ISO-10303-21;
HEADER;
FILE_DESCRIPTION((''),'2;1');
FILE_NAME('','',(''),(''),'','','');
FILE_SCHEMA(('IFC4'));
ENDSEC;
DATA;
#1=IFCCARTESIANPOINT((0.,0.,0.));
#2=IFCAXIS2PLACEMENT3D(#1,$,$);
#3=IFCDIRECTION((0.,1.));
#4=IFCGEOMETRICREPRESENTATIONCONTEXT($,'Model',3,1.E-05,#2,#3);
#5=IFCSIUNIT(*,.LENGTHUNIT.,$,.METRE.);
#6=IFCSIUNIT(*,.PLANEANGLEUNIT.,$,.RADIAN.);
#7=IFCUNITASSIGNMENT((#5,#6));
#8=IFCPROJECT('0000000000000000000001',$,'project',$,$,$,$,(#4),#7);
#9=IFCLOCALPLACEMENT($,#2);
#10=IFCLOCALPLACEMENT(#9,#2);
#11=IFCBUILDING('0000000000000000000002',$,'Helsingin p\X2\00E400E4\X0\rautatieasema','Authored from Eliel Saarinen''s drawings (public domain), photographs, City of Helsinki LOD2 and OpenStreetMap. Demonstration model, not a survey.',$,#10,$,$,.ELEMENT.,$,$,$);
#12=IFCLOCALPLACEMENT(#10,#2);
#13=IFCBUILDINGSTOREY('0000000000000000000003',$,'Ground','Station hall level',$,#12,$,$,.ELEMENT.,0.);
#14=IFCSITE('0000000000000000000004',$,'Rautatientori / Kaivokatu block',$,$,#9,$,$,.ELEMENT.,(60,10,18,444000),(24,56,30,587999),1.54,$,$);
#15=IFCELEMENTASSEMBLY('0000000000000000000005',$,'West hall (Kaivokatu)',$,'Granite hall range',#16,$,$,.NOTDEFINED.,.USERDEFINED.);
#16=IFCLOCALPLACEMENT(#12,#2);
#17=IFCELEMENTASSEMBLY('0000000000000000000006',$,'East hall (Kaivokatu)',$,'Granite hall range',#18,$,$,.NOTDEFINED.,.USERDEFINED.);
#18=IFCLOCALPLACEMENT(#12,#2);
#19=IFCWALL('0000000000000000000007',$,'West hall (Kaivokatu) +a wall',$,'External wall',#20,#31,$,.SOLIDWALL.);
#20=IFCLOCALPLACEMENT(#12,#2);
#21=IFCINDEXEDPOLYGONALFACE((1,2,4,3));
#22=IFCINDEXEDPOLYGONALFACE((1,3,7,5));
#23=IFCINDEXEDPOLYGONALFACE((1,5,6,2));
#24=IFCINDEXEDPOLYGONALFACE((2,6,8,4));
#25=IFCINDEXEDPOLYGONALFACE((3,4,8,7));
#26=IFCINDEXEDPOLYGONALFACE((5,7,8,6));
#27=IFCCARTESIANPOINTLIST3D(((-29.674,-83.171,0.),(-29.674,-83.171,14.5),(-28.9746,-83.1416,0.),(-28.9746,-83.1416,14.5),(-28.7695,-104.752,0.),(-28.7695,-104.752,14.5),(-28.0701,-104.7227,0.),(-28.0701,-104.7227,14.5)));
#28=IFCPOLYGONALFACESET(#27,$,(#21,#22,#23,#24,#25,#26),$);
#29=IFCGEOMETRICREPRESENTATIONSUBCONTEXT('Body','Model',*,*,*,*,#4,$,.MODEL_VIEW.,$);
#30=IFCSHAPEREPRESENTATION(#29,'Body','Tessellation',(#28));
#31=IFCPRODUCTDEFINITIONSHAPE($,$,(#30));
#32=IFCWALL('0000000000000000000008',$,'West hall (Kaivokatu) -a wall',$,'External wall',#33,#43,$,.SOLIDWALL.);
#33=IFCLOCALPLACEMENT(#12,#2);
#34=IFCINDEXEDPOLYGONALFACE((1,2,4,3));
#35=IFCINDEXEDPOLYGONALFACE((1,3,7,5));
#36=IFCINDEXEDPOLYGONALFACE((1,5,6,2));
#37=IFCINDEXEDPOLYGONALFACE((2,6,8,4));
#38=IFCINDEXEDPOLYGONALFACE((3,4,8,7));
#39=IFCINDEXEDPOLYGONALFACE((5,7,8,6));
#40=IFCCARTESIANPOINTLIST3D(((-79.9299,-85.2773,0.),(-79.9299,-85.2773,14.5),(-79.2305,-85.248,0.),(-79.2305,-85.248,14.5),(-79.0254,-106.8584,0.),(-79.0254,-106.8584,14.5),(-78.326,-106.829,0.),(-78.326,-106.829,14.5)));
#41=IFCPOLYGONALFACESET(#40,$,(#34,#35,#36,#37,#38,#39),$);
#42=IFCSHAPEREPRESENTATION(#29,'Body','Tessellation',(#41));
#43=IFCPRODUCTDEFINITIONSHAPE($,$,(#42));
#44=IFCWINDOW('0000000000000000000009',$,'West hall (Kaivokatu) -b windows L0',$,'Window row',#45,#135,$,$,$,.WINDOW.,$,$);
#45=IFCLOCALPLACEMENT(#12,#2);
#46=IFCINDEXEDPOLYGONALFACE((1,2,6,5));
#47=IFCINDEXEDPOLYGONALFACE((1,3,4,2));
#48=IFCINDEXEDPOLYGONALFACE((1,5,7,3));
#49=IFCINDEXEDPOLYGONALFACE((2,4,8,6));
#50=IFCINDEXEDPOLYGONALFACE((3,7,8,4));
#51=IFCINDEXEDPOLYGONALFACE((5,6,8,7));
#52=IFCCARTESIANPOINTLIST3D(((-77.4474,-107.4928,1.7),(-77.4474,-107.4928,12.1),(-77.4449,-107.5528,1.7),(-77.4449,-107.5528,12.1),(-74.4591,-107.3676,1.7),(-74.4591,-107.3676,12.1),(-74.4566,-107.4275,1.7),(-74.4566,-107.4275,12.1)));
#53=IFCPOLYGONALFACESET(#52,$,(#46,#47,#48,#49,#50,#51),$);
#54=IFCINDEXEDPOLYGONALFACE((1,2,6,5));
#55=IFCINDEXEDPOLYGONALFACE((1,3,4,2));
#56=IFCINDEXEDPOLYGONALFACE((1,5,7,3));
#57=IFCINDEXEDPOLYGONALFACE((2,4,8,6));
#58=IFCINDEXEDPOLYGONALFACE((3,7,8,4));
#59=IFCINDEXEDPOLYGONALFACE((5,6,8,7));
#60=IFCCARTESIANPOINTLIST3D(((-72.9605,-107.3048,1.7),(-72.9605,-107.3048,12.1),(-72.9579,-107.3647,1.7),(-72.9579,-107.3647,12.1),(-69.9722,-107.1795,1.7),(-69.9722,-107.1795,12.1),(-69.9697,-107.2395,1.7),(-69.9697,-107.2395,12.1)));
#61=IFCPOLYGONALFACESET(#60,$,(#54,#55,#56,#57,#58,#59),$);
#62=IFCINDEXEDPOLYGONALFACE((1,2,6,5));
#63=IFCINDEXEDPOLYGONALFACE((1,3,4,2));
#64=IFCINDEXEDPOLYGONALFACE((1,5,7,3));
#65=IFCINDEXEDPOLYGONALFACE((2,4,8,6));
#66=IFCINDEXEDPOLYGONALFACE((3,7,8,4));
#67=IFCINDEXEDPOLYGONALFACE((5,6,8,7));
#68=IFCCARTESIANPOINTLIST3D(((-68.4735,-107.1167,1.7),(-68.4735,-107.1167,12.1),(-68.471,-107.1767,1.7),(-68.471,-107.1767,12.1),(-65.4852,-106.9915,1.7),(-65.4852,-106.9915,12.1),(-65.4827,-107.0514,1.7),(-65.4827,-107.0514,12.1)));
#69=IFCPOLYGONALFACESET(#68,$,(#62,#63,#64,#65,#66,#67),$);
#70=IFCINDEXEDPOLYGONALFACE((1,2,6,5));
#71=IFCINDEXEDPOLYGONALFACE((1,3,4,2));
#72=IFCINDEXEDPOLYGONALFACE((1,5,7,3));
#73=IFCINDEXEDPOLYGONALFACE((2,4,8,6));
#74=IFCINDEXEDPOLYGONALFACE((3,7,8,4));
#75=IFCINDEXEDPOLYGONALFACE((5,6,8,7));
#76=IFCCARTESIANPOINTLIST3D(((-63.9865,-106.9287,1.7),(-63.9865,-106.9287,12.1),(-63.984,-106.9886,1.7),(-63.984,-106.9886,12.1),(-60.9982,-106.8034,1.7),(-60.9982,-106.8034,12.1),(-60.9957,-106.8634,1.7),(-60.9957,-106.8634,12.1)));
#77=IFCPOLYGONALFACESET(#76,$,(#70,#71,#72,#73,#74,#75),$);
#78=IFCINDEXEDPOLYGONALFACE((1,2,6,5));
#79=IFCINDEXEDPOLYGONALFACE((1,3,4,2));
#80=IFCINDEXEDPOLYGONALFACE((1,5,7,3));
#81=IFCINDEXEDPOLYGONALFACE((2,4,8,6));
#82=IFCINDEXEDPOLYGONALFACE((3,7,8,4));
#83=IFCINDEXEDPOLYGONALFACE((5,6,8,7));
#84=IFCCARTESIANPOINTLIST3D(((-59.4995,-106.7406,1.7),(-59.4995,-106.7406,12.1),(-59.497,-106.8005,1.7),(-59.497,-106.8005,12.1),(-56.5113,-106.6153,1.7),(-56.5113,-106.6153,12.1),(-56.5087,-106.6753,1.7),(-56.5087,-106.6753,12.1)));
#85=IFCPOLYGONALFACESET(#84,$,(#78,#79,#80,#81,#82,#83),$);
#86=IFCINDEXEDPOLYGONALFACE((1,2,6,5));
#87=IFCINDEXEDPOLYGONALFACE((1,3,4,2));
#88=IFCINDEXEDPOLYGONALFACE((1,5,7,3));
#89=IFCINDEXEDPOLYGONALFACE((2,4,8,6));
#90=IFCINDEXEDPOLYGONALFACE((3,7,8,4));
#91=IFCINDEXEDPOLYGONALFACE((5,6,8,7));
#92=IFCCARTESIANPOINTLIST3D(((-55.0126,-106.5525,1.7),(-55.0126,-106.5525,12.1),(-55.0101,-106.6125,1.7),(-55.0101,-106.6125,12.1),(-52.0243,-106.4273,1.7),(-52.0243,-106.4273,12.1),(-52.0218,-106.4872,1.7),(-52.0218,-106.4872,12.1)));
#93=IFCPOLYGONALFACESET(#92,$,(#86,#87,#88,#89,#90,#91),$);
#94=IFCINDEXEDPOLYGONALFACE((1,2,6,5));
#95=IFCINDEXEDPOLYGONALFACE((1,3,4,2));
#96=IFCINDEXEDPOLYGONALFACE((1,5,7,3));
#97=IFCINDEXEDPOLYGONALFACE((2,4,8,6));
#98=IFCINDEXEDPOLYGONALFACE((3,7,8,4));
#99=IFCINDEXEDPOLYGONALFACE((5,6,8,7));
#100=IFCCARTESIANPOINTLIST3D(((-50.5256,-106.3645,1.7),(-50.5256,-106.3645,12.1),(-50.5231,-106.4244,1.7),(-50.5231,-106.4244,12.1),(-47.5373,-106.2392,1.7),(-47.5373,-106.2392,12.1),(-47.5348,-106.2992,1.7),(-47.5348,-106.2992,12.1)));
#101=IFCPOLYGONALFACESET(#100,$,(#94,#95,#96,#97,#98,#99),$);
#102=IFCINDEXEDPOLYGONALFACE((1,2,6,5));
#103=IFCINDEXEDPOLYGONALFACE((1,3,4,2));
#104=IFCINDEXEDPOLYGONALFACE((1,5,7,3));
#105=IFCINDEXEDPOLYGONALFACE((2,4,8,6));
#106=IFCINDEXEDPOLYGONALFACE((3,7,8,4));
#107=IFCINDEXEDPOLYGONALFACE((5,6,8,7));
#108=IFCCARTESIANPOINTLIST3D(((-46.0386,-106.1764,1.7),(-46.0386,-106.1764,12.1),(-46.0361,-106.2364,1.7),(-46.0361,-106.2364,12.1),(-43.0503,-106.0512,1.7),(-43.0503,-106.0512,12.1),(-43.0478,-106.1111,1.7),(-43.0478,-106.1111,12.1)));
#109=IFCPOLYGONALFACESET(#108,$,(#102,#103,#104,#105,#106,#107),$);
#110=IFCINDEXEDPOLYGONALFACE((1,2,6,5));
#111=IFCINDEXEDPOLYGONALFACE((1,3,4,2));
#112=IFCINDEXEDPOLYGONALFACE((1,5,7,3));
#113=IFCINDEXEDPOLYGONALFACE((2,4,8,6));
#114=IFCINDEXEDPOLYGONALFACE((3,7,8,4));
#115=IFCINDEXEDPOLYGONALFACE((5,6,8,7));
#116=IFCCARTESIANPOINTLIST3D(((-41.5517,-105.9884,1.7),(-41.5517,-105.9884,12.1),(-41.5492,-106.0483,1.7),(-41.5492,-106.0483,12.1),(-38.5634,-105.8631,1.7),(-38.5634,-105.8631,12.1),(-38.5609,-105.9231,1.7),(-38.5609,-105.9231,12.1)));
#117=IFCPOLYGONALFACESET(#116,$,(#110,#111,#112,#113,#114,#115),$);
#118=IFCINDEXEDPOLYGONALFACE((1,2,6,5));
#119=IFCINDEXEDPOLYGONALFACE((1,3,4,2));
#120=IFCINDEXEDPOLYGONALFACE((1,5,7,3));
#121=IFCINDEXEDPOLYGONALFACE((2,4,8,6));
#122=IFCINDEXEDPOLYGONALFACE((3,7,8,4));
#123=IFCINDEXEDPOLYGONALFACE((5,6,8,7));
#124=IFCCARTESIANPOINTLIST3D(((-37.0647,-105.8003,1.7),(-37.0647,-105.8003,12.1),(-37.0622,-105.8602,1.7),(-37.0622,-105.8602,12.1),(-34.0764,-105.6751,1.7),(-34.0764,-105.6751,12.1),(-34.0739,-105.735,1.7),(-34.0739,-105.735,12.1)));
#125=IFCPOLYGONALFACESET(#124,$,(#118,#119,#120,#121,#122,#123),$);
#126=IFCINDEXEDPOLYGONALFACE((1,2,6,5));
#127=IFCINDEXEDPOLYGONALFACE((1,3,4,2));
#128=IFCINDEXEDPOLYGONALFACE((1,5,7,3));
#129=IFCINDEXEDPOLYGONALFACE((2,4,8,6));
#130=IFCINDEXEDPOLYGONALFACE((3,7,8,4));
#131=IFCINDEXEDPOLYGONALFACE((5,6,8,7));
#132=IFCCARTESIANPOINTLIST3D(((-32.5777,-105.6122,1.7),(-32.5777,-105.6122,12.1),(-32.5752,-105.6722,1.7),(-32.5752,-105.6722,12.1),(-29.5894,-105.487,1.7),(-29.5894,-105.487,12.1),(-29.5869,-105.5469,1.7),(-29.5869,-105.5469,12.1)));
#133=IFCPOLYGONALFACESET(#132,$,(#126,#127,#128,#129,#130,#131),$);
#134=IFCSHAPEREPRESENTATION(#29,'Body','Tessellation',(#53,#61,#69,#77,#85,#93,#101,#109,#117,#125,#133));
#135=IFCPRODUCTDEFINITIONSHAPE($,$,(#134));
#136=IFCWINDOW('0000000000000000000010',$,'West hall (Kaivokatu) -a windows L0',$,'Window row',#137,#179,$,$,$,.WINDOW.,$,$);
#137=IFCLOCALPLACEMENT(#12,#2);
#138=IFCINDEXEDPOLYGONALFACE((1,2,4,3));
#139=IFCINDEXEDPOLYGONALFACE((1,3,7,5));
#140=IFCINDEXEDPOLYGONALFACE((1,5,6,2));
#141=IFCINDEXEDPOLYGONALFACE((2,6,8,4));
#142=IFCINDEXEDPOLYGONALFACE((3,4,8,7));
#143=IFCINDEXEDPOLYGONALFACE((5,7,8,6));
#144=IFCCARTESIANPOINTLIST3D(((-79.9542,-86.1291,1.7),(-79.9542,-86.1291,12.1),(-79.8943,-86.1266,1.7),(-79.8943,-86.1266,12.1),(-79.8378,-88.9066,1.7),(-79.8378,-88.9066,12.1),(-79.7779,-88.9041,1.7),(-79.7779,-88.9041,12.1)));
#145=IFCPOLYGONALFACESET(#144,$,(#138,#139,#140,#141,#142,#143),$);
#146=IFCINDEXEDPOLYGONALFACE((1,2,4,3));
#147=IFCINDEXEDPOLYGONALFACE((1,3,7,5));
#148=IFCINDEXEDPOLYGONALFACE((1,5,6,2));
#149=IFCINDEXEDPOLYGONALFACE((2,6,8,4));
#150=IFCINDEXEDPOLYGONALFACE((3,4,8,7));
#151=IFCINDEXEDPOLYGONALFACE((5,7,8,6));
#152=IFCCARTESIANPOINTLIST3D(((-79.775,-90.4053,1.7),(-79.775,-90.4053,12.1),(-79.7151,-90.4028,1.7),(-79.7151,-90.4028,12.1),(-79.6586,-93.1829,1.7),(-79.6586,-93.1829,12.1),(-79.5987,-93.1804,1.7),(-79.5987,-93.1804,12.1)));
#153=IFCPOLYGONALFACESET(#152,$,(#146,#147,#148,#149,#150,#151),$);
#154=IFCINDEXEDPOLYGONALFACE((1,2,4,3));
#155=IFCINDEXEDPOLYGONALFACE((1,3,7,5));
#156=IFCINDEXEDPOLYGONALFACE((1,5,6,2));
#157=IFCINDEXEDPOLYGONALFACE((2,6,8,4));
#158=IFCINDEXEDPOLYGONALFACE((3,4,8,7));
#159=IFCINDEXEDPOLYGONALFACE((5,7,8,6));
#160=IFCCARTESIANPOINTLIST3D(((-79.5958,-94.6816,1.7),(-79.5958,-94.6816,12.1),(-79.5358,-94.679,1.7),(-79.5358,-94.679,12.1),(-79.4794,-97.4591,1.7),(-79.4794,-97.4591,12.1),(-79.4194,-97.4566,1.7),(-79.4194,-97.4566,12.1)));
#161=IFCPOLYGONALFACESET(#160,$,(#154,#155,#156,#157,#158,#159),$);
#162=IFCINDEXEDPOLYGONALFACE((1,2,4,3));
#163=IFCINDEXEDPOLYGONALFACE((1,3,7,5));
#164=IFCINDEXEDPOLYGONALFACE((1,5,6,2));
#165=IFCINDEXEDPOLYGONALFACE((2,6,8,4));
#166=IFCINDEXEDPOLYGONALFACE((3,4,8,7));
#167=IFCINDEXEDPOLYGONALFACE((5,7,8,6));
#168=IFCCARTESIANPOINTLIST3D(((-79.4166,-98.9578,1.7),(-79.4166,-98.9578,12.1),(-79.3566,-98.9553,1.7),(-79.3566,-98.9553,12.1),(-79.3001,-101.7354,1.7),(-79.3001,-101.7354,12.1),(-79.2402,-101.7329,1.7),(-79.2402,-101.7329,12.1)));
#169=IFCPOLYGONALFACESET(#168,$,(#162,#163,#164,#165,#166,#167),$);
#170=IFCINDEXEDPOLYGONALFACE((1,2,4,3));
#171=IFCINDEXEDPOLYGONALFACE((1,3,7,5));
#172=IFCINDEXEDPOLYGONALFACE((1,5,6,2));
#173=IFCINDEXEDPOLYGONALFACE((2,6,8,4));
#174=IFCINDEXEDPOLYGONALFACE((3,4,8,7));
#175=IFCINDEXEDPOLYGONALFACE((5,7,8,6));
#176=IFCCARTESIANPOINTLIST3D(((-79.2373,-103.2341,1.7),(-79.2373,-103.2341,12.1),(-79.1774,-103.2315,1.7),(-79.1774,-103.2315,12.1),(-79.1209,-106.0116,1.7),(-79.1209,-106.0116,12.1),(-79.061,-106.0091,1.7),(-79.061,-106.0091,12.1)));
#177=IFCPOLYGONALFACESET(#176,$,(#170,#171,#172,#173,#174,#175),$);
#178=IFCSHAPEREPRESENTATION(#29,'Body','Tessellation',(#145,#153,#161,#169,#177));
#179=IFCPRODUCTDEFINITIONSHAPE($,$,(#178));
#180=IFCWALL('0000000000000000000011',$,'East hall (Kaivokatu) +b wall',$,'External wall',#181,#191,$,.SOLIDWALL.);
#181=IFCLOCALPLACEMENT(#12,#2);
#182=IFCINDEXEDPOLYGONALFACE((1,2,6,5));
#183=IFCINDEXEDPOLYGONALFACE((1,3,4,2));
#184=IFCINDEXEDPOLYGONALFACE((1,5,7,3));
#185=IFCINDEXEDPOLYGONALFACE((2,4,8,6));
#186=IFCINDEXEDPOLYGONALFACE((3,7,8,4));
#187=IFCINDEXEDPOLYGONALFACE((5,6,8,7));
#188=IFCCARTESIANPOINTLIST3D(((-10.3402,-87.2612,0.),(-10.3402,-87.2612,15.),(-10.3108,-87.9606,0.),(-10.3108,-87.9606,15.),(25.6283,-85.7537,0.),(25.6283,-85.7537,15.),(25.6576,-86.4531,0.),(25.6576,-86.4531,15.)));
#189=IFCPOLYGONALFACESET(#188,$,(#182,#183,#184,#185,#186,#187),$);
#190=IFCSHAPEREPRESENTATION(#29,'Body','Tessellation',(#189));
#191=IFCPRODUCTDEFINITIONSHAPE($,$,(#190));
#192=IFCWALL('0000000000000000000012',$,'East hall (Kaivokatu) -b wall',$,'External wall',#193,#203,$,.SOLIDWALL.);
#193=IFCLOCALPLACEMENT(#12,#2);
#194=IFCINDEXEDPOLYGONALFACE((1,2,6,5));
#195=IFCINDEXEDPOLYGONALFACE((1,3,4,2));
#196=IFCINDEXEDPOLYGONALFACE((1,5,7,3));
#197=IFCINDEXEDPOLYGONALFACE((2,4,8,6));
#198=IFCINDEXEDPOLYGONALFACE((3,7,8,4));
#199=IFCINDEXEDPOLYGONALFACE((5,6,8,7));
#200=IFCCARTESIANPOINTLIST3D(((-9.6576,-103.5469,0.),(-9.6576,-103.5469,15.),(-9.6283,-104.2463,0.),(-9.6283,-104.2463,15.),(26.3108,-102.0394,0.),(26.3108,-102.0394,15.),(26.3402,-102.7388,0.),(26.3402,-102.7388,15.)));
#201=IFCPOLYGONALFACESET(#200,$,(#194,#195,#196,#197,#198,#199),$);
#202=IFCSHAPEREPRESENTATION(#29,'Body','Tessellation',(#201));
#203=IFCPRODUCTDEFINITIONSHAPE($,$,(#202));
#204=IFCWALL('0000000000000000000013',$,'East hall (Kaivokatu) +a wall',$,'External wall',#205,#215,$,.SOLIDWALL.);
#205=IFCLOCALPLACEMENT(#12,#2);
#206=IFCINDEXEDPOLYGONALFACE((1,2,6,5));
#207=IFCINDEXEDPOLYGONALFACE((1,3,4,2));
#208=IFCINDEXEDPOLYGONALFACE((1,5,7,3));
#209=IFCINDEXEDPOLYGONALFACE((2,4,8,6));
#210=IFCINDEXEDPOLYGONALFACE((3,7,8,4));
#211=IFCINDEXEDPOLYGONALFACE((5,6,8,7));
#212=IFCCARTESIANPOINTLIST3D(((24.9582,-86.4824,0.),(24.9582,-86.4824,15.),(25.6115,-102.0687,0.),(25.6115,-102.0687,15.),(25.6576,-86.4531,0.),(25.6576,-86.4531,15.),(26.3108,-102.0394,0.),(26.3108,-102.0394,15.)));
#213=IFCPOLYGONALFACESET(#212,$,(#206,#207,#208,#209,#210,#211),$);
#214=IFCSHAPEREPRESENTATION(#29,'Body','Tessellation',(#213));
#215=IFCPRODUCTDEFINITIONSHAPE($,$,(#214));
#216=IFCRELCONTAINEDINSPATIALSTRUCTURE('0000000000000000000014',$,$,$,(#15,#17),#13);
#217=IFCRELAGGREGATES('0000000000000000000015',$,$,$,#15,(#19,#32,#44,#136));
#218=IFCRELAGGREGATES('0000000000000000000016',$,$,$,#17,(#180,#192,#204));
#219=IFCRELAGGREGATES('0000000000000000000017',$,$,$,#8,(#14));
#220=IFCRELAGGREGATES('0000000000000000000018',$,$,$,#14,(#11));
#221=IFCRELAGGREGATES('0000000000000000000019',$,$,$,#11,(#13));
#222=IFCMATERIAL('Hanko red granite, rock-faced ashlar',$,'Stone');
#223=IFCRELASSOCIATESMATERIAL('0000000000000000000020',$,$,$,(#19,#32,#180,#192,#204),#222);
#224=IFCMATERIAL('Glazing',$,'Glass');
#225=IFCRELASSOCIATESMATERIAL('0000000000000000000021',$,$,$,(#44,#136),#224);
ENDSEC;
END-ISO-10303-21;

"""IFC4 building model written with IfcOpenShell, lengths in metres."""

from ifc_helpers import new_model, si_unit, direction, frame, frame_2d, origin, place, context, subcontext, project, spatial, rectangle, extrude, material, element, aggregate, save


model = new_model("IFC4")

# Units and contexts
model_context = context("Model", 3, precision=1e-05, world=origin(), true_north=direction((0.0, 1.0)))
body_context = subcontext(model_context, "Body", "Model", "MODEL_VIEW")
ifc_project = project(units=[si_unit("LENGTHUNIT", "METRE"), si_unit("PLANEANGLEUNIT", "RADIAN")], contexts=[model_context])

# Site, building, storey
site_placement = place(None, origin())
site = spatial("IfcSite", under=ifc_project, at=site_placement, Name="Rautatientori / Kaivokatu block", CompositionType="ELEMENT", RefLatitude=(60, 10, 18, 444000), RefLongitude=(24, 56, 30, 587999), RefElevation=1.54)
building_placement = place(site_placement, origin())
building = spatial("IfcBuilding", under=site, at=building_placement, Name="Helsingin päärautatieasema", Description="Authored from Eliel Saarinen's drawings (public domain), photographs, City of Helsinki LOD2 and OpenStreetMap. Demonstration model, not a survey.", CompositionType="ELEMENT")
storey_placement = place(building_placement, origin())
storey = spatial("IfcBuildingStorey", under=building, at=storey_placement, Name="Ground", Description="Station hall level", CompositionType="ELEMENT", Elevation=0.0)

# Element assemblies
assembly_1_placement = place(building_placement, origin())
assembly_1 = element("IfcElementAssembly", 1, at=assembly_1_placement, inside=storey, Name="West hall (Kaivokatu)", ObjectType="Granite hall range", AssemblyPlace="NOTDEFINED", PredefinedType="USERDEFINED")
ifc_material_1 = material(Name="Hanko red granite, rock-faced ashlar", Category="Stone")
assembly_2_placement = place(building_placement, origin())
assembly_2 = element("IfcElementAssembly", 2, at=assembly_2_placement, inside=storey, Name="East hall (Kaivokatu)", ObjectType="Granite hall range", AssemblyPlace="NOTDEFINED", PredefinedType="USERDEFINED")

# Walls
wall_1_placement = place(building_placement, origin())
wall_1 = element("IfcWall", 3, at=wall_1_placement, material=ifc_material_1, Name="West hall (Kaivokatu) +a wall", ObjectType="External wall", PredefinedType="SOLIDWALL", context=body_context, shape_type="SweptSolid", body=[
    extrude(rectangle(XDim=21.6, YDim=0.7, at=frame_2d((0.0, 0.0), x_axis=(-0.041876, 0.999123))), frame((-28.8721, -93.9468, 0.0)), (0.0, 0.0, 1.0), 14.5),
])
wall_2_placement = place(building_placement, origin())
wall_2 = element("IfcWall", 4, at=wall_2_placement, material=ifc_material_1, Name="West hall (Kaivokatu) -a wall", ObjectType="External wall", PredefinedType="SOLIDWALL", context=body_context, shape_type="SweptSolid", body=[
    extrude(rectangle(XDim=21.6, YDim=0.7, at=frame_2d((0.0, 0.0), x_axis=(0.041876, -0.999123))), frame((-79.1279, -96.0532, 0.0)), (0.0, 0.0, 1.0), 14.5),
])

# Windows
ifc_material_2 = material(Name="Glazing", Category="Glass")
window_1_placement = place(building_placement, origin())
window_1 = element("IfcWindow", 5, at=window_1_placement, material=ifc_material_2, Name="West hall (Kaivokatu) -b windows L0", ObjectType="Window row", PredefinedType="WINDOW", context=body_context, shape_type="SweptSolid", body=[
    extrude(rectangle(XDim=2.9909, YDim=0.06, at=frame_2d((0.0, 0.0), x_axis=(0.999123, 0.041876))), frame((-75.952, -107.4602, 1.7)), (0.0, 0.0, 1.0), 10.4),
    extrude(rectangle(XDim=2.9909, YDim=0.06, at=frame_2d((0.0, 0.0), x_axis=(0.999123, 0.041876))), frame((-71.4651, -107.2721, 1.7)), (0.0, 0.0, 1.0), 10.4),
    extrude(rectangle(XDim=2.9909, YDim=0.06, at=frame_2d((0.0, 0.0), x_axis=(0.999123, 0.041876))), frame((-66.9781, -107.0841, 1.7)), (0.0, 0.0, 1.0), 10.4),
    extrude(rectangle(XDim=2.9909, YDim=0.06, at=frame_2d((0.0, 0.0), x_axis=(0.999123, 0.041876))), frame((-62.4911, -106.896, 1.7)), (0.0, 0.0, 1.0), 10.4),
    extrude(rectangle(XDim=2.9909, YDim=0.06, at=frame_2d((0.0, 0.0), x_axis=(0.999123, 0.041876))), frame((-58.0041, -106.7079, 1.7)), (0.0, 0.0, 1.0), 10.4),
    extrude(rectangle(XDim=2.9909, YDim=0.06, at=frame_2d((0.0, 0.0), x_axis=(0.999123, 0.041876))), frame((-53.5172, -106.5199, 1.7)), (0.0, 0.0, 1.0), 10.4),
    extrude(rectangle(XDim=2.9909, YDim=0.06, at=frame_2d((0.0, 0.0), x_axis=(0.999123, 0.041876))), frame((-49.0302, -106.3318, 1.7)), (0.0, 0.0, 1.0), 10.4),
    extrude(rectangle(XDim=2.9909, YDim=0.06, at=frame_2d((0.0, 0.0), x_axis=(0.999123, 0.041876))), frame((-44.5432, -106.1438, 1.7)), (0.0, 0.0, 1.0), 10.4),
    extrude(rectangle(XDim=2.9909, YDim=0.06, at=frame_2d((0.0, 0.0), x_axis=(0.999123, 0.041876))), frame((-40.0563, -105.9557, 1.7)), (0.0, 0.0, 1.0), 10.4),
    extrude(rectangle(XDim=2.9909, YDim=0.06, at=frame_2d((0.0, 0.0), x_axis=(0.999123, 0.041876))), frame((-35.5693, -105.7676, 1.7)), (0.0, 0.0, 1.0), 10.4),
    extrude(rectangle(XDim=2.9909, YDim=0.06, at=frame_2d((0.0, 0.0), x_axis=(0.999123, 0.041876))), frame((-31.0823, -105.5796, 1.7)), (0.0, 0.0, 1.0), 10.4),
])
window_2_placement = place(building_placement, origin())
window_2 = element("IfcWindow", 6, at=window_2_placement, material=ifc_material_2, Name="West hall (Kaivokatu) -a windows L0", ObjectType="Window row", PredefinedType="WINDOW", context=body_context, shape_type="SweptSolid", body=[
    extrude(rectangle(XDim=2.78, YDim=0.06, at=frame_2d((0.0, 0.0), x_axis=(0.041876, -0.999123))), frame((-79.8661, -87.5166, 1.7)), (0.0, 0.0, 1.0), 10.4),
    extrude(rectangle(XDim=2.78, YDim=0.06, at=frame_2d((0.0, 0.0), x_axis=(0.041876, -0.999123))), frame((-79.6868, -91.7928, 1.7)), (0.0, 0.0, 1.0), 10.4),
    extrude(rectangle(XDim=2.78, YDim=0.06, at=frame_2d((0.0, 0.0), x_axis=(0.041876, -0.999123))), frame((-79.5076, -96.0691, 1.7)), (0.0, 0.0, 1.0), 10.4),
    extrude(rectangle(XDim=2.78, YDim=0.06, at=frame_2d((0.0, 0.0), x_axis=(0.041876, -0.999123))), frame((-79.3284, -100.3453, 1.7)), (0.0, 0.0, 1.0), 10.4),
    extrude(rectangle(XDim=2.78, YDim=0.06, at=frame_2d((0.0, 0.0), x_axis=(0.041876, -0.999123))), frame((-79.1492, -104.6216, 1.7)), (0.0, 0.0, 1.0), 10.4),
])

# Walls
wall_3_placement = place(building_placement, origin())
wall_3 = element("IfcWall", 7, at=wall_3_placement, material=ifc_material_1, Name="East hall (Kaivokatu) +b wall", ObjectType="External wall", PredefinedType="SOLIDWALL", context=body_context, shape_type="SweptSolid", body=[
    extrude(rectangle(XDim=36.0, YDim=0.7, at=frame_2d((0.0, 0.0), x_axis=(-0.999123, -0.041876))), frame((7.6587, -86.8571, 0.0)), (0.0, 0.0, 1.0), 15.0),
])
wall_4_placement = place(building_placement, origin())
wall_4 = element("IfcWall", 8, at=wall_4_placement, material=ifc_material_1, Name="East hall (Kaivokatu) -b wall", ObjectType="External wall", PredefinedType="SOLIDWALL", context=body_context, shape_type="SweptSolid", body=[
    extrude(rectangle(XDim=36.0, YDim=0.7, at=frame_2d((0.0, 0.0), x_axis=(0.999123, 0.041876))), frame((8.3413, -103.1429, 0.0)), (0.0, 0.0, 1.0), 15.0),
])
wall_5_placement = place(building_placement, origin())
wall_5 = element("IfcWall", 9, at=wall_5_placement, material=ifc_material_1, Name="East hall (Kaivokatu) +a wall", ObjectType="External wall", PredefinedType="SOLIDWALL", context=body_context, shape_type="SweptSolid", body=[
    extrude(rectangle(XDim=15.6, YDim=0.7, at=frame_2d((0.0, 0.0), x_axis=(-0.041876, 0.999123))), frame((25.6345, -94.2609, 0.0)), (0.0, 0.0, 1.0), 15.0),
])

aggregate(assembly_1, [wall_1, wall_2, window_1, window_2])
aggregate(assembly_2, [wall_3, wall_4, wall_5])

save(model, "model.ifc")
